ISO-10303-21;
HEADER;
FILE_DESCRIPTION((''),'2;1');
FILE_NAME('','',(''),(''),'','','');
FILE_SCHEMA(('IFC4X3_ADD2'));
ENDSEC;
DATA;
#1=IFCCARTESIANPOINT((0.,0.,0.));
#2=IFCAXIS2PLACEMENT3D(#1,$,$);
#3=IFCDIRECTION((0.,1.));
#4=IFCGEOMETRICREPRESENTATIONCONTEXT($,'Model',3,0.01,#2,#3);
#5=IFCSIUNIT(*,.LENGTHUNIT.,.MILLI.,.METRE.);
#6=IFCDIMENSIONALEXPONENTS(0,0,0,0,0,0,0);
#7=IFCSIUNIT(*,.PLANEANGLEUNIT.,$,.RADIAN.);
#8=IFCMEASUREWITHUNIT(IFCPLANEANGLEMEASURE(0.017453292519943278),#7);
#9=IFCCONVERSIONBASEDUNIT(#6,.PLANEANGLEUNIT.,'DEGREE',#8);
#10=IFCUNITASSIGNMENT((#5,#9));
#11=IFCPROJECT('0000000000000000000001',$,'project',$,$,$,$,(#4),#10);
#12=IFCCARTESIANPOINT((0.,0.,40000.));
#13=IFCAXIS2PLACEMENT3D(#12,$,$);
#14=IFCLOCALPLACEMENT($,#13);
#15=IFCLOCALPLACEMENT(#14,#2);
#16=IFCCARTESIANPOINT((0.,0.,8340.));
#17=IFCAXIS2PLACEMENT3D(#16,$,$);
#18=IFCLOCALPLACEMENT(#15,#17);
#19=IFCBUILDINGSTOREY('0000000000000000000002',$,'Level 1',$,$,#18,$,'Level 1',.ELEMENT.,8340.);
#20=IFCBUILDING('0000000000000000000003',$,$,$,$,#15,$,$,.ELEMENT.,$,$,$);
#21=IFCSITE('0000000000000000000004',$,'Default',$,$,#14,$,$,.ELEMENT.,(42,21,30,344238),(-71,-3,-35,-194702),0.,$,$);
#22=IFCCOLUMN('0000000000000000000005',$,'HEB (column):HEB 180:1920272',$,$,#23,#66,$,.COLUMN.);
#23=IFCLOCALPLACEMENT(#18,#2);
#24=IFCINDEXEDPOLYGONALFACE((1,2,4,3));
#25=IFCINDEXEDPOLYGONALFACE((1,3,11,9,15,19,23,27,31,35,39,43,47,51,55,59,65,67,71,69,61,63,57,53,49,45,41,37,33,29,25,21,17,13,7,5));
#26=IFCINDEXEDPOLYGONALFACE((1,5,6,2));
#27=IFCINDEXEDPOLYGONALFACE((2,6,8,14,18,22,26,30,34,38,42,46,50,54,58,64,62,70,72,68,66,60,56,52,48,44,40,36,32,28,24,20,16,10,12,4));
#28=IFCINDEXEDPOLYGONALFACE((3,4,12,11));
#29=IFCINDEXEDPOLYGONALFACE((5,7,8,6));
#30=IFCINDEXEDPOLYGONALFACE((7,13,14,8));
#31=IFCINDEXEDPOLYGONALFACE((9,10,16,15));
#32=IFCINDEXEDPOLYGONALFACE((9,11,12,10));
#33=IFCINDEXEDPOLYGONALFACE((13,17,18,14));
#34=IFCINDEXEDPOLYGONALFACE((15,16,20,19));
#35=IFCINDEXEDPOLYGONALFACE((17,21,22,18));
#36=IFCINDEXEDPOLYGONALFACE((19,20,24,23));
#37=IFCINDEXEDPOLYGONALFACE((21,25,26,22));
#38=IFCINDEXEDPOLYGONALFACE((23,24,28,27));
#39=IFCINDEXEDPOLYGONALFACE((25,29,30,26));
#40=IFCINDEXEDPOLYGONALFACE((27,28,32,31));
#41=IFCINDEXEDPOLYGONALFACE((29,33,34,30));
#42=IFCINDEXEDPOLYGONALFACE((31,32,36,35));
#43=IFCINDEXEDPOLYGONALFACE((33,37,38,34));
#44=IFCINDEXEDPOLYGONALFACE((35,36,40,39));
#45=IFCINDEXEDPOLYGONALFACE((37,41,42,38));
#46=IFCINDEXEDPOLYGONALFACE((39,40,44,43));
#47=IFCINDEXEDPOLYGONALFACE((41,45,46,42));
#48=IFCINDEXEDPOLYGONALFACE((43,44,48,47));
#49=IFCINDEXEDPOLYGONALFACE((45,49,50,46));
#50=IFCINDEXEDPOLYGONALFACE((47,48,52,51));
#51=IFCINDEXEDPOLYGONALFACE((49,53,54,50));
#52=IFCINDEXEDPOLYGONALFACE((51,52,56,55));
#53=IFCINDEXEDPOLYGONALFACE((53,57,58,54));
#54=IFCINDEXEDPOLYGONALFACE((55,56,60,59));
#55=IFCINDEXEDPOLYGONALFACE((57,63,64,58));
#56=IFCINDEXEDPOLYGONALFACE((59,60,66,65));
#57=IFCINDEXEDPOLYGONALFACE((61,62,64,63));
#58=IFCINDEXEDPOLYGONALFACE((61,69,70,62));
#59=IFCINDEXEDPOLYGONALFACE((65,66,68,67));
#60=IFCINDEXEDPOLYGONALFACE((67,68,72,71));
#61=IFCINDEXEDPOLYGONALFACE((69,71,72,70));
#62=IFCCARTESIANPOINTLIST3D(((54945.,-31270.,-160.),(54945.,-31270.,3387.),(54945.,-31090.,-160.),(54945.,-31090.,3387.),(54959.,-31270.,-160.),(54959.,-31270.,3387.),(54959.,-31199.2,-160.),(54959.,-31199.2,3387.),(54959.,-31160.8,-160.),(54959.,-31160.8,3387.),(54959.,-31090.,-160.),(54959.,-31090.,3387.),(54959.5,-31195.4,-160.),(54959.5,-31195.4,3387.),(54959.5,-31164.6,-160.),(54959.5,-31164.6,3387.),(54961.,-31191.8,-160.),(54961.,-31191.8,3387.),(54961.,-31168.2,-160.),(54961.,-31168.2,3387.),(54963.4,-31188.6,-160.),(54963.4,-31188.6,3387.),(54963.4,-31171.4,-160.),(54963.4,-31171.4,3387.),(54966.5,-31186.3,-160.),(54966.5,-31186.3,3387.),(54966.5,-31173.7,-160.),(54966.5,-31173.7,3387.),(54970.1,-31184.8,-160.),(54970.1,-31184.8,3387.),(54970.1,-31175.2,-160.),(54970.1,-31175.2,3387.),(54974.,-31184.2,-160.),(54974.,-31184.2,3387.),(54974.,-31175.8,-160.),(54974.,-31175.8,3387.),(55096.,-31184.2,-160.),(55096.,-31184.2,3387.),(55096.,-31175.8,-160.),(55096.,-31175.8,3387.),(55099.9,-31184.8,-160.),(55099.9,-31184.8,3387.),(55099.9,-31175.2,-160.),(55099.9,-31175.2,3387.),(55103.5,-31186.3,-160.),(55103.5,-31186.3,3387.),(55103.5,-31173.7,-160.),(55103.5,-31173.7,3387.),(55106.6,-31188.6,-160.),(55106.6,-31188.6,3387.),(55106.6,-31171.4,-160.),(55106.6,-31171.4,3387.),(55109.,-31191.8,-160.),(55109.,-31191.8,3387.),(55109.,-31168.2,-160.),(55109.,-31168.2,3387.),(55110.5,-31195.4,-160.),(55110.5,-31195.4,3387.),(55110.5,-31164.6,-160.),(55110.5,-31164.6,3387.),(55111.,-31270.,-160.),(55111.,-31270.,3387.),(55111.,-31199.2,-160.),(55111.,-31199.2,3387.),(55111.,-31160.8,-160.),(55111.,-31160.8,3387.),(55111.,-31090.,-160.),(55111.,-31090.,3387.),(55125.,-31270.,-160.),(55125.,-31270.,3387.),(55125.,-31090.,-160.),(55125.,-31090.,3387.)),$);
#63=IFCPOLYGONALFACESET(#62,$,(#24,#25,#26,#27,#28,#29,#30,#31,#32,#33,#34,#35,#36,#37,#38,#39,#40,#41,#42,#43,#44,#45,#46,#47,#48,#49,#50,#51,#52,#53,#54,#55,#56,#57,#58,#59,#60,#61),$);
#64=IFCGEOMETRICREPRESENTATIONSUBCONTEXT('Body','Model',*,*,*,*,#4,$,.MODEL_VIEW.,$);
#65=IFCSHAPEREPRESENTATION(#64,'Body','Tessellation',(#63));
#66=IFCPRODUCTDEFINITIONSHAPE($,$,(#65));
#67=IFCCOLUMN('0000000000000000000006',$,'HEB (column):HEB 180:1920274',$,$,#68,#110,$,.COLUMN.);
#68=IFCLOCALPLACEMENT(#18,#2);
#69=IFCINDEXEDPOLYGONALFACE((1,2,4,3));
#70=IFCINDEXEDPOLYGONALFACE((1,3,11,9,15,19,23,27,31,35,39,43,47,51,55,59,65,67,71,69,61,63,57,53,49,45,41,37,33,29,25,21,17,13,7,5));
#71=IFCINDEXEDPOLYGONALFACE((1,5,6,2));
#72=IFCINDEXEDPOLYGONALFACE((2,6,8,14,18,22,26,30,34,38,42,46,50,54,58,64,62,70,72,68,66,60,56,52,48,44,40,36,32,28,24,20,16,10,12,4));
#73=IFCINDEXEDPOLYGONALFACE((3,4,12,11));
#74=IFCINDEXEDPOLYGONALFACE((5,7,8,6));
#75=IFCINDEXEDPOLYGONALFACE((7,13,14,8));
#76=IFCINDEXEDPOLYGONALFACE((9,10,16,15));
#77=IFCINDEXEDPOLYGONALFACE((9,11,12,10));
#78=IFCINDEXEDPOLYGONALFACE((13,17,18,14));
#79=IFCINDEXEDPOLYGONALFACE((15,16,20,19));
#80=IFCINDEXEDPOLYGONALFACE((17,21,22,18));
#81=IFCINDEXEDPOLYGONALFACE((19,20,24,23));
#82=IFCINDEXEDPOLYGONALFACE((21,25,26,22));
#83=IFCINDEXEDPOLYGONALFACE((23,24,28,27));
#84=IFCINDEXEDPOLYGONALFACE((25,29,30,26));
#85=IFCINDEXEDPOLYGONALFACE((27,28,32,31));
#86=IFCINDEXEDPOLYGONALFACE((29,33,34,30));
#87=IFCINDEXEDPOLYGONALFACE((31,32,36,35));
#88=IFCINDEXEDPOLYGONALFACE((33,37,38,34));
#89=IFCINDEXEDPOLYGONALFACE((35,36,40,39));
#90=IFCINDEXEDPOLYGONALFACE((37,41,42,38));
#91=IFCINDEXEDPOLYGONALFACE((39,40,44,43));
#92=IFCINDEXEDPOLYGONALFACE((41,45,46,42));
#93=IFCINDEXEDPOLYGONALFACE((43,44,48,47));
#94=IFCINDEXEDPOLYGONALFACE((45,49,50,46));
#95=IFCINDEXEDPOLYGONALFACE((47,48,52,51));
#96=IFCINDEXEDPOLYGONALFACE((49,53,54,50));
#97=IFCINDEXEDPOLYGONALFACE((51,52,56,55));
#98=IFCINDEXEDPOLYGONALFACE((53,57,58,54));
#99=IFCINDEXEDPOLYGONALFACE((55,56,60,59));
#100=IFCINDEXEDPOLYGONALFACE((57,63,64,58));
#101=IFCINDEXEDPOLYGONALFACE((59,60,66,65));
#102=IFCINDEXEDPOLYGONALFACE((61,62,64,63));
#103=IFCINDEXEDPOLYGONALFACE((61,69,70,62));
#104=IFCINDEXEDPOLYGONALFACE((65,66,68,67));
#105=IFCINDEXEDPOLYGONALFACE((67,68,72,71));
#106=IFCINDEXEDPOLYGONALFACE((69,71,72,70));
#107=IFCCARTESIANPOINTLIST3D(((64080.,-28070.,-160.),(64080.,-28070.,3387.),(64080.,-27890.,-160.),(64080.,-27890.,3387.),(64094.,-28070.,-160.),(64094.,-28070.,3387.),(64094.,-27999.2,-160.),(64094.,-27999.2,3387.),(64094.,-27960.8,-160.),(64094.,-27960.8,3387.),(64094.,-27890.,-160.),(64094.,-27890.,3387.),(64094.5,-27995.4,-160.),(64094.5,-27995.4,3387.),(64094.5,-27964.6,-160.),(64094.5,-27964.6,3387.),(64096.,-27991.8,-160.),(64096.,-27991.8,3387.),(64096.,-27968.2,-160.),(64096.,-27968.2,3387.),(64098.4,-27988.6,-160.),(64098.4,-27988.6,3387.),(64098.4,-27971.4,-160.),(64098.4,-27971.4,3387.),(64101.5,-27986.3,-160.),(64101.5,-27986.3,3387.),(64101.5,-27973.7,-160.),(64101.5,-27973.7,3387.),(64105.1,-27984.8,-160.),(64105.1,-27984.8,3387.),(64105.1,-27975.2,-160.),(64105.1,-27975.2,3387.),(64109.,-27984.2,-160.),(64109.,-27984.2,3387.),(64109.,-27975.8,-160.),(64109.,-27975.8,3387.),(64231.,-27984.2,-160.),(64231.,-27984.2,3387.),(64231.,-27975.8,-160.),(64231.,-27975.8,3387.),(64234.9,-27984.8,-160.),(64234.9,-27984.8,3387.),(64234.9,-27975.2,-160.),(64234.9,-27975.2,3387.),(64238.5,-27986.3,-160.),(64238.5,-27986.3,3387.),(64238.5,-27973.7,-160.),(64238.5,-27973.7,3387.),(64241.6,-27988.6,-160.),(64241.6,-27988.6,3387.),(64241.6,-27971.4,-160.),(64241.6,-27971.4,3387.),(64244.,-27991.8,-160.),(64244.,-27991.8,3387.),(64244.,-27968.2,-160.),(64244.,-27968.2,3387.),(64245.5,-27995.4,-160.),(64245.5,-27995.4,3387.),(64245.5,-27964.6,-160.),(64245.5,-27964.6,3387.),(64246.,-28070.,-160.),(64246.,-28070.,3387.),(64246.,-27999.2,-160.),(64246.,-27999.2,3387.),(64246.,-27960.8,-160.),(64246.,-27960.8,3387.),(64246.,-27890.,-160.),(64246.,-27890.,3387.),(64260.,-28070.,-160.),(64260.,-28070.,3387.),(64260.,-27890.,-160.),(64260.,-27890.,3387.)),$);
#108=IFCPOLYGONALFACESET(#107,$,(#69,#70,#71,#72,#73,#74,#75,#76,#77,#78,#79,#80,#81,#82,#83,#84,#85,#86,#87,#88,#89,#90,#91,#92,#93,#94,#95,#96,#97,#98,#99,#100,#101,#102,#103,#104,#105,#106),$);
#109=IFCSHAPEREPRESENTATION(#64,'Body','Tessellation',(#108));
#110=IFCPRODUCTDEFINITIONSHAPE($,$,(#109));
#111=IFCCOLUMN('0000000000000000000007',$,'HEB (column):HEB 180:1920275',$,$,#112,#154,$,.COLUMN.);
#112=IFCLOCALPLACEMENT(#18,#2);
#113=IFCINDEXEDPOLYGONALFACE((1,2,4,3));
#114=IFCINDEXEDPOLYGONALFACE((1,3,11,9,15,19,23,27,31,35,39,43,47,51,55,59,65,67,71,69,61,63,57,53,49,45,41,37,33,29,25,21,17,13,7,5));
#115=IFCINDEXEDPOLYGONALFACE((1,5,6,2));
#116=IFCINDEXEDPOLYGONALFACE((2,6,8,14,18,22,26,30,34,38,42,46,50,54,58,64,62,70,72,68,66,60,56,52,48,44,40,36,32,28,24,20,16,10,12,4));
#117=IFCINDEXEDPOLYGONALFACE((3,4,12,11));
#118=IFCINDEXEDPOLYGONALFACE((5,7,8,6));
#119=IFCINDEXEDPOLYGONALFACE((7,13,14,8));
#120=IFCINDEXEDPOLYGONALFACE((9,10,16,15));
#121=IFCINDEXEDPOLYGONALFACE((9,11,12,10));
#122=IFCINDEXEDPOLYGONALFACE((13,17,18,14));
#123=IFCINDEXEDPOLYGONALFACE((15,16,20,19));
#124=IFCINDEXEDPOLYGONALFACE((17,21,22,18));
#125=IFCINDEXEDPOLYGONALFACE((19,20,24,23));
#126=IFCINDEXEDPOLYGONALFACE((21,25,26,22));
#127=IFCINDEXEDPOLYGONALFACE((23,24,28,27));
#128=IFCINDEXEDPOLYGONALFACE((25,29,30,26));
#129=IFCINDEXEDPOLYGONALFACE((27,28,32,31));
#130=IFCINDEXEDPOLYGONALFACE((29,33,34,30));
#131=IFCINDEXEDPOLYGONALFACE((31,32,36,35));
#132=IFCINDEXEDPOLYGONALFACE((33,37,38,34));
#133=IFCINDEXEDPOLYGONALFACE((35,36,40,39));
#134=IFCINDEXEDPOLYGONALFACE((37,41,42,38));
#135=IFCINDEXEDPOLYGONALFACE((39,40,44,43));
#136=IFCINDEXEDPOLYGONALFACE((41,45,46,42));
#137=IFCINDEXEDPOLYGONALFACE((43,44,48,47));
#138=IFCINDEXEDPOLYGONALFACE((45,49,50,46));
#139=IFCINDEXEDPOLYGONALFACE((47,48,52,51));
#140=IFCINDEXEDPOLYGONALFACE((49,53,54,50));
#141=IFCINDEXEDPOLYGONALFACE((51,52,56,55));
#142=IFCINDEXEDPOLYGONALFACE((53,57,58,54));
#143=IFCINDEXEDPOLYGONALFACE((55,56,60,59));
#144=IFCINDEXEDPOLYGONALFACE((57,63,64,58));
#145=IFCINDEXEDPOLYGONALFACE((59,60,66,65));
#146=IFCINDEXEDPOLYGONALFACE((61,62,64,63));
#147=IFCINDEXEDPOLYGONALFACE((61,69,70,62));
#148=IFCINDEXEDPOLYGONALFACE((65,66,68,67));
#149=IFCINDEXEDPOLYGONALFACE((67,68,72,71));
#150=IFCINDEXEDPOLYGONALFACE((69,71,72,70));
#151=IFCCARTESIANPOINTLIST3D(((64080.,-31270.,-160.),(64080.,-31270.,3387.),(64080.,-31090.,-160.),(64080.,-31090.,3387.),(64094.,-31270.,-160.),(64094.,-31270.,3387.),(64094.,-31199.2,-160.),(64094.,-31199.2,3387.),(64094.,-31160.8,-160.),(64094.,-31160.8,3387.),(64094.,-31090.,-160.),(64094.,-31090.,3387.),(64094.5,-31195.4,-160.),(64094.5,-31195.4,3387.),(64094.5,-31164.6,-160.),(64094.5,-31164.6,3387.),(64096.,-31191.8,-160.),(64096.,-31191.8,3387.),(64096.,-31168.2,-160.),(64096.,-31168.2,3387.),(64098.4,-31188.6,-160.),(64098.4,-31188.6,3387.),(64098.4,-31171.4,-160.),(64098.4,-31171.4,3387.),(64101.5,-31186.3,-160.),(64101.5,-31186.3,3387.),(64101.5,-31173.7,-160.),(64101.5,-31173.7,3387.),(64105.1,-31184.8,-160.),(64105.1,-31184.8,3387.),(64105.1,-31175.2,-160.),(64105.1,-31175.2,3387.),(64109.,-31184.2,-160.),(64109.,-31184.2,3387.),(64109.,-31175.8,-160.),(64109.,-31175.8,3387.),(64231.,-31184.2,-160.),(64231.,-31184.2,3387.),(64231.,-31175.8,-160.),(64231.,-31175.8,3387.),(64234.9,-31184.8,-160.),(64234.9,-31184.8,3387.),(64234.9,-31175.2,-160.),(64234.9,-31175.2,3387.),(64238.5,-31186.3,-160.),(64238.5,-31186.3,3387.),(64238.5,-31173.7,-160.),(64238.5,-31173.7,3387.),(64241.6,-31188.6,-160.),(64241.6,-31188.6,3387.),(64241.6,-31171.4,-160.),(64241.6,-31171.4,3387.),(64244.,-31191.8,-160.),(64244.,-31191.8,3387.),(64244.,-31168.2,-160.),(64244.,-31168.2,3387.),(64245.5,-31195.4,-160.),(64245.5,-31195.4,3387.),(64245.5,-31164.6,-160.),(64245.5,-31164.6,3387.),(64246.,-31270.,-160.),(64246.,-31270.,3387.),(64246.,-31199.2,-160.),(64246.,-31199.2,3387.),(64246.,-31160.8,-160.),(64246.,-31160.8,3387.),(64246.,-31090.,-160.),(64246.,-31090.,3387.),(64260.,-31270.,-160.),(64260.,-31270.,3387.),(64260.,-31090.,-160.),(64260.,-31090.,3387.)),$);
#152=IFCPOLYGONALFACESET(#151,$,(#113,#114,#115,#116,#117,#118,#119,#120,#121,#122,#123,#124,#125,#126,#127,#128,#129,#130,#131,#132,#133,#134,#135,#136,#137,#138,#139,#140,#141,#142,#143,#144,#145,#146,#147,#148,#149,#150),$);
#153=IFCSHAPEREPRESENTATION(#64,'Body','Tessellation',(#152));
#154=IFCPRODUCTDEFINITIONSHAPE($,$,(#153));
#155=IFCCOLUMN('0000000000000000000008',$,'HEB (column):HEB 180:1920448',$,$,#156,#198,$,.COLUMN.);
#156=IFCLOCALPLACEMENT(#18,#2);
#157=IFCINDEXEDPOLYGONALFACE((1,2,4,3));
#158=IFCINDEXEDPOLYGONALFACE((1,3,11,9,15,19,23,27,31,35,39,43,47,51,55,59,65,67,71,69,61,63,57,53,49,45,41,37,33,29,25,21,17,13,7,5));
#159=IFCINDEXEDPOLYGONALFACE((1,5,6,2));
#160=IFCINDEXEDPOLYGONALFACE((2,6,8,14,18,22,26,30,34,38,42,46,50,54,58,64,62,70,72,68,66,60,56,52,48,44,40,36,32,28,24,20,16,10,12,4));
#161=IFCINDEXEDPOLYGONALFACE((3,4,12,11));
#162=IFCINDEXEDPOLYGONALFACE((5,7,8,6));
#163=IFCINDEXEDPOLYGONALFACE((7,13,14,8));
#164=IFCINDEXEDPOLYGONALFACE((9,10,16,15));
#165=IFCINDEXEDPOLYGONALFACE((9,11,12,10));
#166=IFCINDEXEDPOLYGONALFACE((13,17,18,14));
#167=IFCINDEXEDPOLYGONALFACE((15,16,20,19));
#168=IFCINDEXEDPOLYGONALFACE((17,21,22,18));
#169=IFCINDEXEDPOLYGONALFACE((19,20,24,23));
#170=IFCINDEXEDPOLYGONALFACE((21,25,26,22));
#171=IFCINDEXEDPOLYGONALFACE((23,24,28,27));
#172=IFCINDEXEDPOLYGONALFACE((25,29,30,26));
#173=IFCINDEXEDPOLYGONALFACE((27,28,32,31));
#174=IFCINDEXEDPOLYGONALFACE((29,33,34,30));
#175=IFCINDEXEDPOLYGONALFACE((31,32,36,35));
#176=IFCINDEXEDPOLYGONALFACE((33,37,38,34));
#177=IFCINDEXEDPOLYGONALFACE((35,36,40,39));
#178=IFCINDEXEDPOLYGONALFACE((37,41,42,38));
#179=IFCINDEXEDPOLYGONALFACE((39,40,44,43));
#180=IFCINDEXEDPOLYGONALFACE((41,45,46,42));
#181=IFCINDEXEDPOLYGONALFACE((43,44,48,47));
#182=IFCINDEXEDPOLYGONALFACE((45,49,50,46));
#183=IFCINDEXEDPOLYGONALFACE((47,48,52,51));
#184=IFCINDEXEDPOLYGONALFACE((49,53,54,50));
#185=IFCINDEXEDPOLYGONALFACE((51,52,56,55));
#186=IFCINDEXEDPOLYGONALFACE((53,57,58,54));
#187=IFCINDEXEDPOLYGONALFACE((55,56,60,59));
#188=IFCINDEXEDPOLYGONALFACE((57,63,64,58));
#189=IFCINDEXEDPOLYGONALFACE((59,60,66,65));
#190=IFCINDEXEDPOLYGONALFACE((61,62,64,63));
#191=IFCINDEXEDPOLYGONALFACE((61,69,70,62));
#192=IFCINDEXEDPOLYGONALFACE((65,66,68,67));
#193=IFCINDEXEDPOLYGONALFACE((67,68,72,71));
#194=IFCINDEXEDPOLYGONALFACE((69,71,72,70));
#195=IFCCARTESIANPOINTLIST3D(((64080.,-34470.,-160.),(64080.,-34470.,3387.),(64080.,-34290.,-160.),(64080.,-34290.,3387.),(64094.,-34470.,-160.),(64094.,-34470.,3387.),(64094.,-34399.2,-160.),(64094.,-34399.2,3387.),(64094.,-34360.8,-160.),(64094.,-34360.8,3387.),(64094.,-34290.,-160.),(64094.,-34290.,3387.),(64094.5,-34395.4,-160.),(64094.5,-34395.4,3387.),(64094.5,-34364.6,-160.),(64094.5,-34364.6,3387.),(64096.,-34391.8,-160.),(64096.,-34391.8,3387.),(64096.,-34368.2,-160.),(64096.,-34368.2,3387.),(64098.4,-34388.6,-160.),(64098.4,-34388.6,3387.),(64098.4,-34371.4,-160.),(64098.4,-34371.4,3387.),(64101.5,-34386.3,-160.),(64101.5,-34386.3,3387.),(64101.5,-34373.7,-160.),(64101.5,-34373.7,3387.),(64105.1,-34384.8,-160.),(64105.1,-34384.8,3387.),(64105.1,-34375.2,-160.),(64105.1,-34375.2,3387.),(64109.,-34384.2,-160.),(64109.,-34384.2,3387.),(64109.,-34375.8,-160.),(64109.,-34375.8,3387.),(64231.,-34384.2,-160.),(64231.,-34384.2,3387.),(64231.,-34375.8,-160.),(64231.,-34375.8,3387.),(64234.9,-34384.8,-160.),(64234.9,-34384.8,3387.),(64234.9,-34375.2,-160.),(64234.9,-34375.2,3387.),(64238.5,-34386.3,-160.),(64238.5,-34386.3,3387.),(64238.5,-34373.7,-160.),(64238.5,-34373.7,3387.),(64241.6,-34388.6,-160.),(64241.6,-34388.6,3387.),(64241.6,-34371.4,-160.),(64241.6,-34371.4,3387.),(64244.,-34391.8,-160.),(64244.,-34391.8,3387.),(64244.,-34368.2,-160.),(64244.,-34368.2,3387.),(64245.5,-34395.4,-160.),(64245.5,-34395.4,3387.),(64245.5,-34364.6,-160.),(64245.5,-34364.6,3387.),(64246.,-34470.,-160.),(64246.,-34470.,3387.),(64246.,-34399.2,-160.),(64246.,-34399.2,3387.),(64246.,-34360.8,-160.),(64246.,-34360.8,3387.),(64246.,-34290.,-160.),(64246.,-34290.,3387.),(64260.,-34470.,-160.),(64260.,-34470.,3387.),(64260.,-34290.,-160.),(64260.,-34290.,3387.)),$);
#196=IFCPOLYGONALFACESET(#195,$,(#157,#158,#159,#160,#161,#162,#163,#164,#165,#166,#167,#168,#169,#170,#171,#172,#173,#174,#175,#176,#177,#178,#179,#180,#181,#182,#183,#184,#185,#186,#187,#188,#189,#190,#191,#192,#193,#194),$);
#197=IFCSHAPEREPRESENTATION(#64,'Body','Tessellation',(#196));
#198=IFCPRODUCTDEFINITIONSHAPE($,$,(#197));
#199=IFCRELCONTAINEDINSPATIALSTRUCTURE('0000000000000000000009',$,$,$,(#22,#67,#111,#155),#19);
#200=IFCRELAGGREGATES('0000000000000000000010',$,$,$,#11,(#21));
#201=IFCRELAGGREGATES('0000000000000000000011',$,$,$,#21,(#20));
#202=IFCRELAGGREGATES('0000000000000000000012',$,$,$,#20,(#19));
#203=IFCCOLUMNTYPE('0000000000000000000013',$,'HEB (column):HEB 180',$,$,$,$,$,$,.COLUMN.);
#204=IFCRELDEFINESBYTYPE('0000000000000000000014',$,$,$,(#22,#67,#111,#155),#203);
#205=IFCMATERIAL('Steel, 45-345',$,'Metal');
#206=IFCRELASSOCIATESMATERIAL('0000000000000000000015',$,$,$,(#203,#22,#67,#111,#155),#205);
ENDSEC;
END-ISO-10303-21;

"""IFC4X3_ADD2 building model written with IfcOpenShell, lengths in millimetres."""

from ifc_helpers import new_model, entity, si_unit, converted_unit, direction, frame, origin, origin_2d_with_axis, place, context, subcontext, project, spatial, i_section, extrude, source, transform, mapped, material, material_profile, profile_set, profile_usage, type_object, type_shapes, element, save


model = new_model("IFC4X3_ADD2")

# Units and contexts
model_context = context("Model", 3, precision=0.01, world=origin(), true_north=direction((0.0, 1.0)))
body_context = subcontext(model_context, "Body", "Model", "MODEL_VIEW")
ifc_project = project(units=[si_unit("LENGTHUNIT", "METRE", prefix="MILLI"), converted_unit("PLANEANGLEUNIT", "DEGREE", entity("IfcPlaneAngleMeasure", 0.017453292519943278), si_unit("PLANEANGLEUNIT", "RADIAN"), dimensions=[0, 0, 0, 0, 0, 0, 0])], contexts=[model_context])

# Site, building, storey
site_placement = place(None, frame((0.0, 0.0, 40000.0)))
site = spatial("IfcSite", under=ifc_project, at=site_placement, Name="Default", CompositionType="ELEMENT", RefLatitude=(42, 21, 30, 344238), RefLongitude=(-71, -3, -35, -194702), RefElevation=0.0)
building_placement = place(site_placement, origin())
building = spatial("IfcBuilding", under=site, at=building_placement, CompositionType="ELEMENT")
storey_placement = place(building_placement, frame((0.0, 0.0, 8340.0)))
storey = spatial("IfcBuildingStorey", under=building, at=storey_placement, Name="Level 1", LongName="Level 1", CompositionType="ELEMENT", Elevation=8340.0)

# Columns
ifc_material_1 = material(Name="Steel, 45-345", Category="Metal")
ifc_material_profile_1 = material_profile(ifc_material_1, i_section(OverallWidth=180.0, OverallDepth=180.0, WebThickness=8.5, FlangeThickness=14.0, FilletRadius=15.0, at=origin_2d_with_axis()), Name="HEB 180")
ifc_profile_set_1 = profile_set([ifc_material_profile_1], Name="HEB 180")
ifc_profile_usage_1 = profile_usage(ifc_profile_set_1)
column_type_1 = type_object("IfcColumnType", Name="HEB (column):HEB 180", PredefinedType="COLUMN", material=ifc_profile_set_1)
shared_shape_1 = source(origin(), body_context, "Body", "SweptSolid", [
    extrude(i_section(OverallWidth=180.0, OverallDepth=180.0, WebThickness=8.5, FlangeThickness=14.0, FilletRadius=15.0, at=origin_2d_with_axis()), frame((0.0, 0.0, 8180.0), z_axis=(0.0, 0.0, 1.0), x_axis=(-1.0, 0.0, 0.0)), (0.0, 0.0, 1.0), 3547.0),
])
type_shapes(column_type_1, [shared_shape_1])
for number, where, z_axis, x_axis, name in (
    (1, (55035.0, -31180.0, -8340.0), (0.0, 0.0, 1.0), (0.0, -1.0, 0.0), "HEB (column):HEB 180:1920272"),
    (2, (64170.0, -27980.0, -8340.0), (0.0, 0.0, 1.0), (0.0, -1.0, 0.0), "HEB (column):HEB 180:1920274"),
    (3, (64170.0, -31180.0, -8340.0), (0.0, 0.0, 1.0), (0.0, -1.0, 0.0), "HEB (column):HEB 180:1920275"),
    (4, (64170.0, -34380.0, -8340.0), (0.0, 0.0, 1.0), (0.0, -1.0, 0.0), "HEB (column):HEB 180:1920448"),
):
    element("IfcColumn", number, at=place(storey_placement, frame(where, z_axis=z_axis, x_axis=x_axis)), inside=storey, type_object=column_type_1, material=ifc_profile_usage_1, Name=name, PredefinedType="COLUMN", context=body_context, shape_type="MappedRepresentation", body=[
        mapped(shared_shape_1, transform((0.0, 0.0, 0.0), scale=1.0)),
    ])

save(model, "model.ifc")
